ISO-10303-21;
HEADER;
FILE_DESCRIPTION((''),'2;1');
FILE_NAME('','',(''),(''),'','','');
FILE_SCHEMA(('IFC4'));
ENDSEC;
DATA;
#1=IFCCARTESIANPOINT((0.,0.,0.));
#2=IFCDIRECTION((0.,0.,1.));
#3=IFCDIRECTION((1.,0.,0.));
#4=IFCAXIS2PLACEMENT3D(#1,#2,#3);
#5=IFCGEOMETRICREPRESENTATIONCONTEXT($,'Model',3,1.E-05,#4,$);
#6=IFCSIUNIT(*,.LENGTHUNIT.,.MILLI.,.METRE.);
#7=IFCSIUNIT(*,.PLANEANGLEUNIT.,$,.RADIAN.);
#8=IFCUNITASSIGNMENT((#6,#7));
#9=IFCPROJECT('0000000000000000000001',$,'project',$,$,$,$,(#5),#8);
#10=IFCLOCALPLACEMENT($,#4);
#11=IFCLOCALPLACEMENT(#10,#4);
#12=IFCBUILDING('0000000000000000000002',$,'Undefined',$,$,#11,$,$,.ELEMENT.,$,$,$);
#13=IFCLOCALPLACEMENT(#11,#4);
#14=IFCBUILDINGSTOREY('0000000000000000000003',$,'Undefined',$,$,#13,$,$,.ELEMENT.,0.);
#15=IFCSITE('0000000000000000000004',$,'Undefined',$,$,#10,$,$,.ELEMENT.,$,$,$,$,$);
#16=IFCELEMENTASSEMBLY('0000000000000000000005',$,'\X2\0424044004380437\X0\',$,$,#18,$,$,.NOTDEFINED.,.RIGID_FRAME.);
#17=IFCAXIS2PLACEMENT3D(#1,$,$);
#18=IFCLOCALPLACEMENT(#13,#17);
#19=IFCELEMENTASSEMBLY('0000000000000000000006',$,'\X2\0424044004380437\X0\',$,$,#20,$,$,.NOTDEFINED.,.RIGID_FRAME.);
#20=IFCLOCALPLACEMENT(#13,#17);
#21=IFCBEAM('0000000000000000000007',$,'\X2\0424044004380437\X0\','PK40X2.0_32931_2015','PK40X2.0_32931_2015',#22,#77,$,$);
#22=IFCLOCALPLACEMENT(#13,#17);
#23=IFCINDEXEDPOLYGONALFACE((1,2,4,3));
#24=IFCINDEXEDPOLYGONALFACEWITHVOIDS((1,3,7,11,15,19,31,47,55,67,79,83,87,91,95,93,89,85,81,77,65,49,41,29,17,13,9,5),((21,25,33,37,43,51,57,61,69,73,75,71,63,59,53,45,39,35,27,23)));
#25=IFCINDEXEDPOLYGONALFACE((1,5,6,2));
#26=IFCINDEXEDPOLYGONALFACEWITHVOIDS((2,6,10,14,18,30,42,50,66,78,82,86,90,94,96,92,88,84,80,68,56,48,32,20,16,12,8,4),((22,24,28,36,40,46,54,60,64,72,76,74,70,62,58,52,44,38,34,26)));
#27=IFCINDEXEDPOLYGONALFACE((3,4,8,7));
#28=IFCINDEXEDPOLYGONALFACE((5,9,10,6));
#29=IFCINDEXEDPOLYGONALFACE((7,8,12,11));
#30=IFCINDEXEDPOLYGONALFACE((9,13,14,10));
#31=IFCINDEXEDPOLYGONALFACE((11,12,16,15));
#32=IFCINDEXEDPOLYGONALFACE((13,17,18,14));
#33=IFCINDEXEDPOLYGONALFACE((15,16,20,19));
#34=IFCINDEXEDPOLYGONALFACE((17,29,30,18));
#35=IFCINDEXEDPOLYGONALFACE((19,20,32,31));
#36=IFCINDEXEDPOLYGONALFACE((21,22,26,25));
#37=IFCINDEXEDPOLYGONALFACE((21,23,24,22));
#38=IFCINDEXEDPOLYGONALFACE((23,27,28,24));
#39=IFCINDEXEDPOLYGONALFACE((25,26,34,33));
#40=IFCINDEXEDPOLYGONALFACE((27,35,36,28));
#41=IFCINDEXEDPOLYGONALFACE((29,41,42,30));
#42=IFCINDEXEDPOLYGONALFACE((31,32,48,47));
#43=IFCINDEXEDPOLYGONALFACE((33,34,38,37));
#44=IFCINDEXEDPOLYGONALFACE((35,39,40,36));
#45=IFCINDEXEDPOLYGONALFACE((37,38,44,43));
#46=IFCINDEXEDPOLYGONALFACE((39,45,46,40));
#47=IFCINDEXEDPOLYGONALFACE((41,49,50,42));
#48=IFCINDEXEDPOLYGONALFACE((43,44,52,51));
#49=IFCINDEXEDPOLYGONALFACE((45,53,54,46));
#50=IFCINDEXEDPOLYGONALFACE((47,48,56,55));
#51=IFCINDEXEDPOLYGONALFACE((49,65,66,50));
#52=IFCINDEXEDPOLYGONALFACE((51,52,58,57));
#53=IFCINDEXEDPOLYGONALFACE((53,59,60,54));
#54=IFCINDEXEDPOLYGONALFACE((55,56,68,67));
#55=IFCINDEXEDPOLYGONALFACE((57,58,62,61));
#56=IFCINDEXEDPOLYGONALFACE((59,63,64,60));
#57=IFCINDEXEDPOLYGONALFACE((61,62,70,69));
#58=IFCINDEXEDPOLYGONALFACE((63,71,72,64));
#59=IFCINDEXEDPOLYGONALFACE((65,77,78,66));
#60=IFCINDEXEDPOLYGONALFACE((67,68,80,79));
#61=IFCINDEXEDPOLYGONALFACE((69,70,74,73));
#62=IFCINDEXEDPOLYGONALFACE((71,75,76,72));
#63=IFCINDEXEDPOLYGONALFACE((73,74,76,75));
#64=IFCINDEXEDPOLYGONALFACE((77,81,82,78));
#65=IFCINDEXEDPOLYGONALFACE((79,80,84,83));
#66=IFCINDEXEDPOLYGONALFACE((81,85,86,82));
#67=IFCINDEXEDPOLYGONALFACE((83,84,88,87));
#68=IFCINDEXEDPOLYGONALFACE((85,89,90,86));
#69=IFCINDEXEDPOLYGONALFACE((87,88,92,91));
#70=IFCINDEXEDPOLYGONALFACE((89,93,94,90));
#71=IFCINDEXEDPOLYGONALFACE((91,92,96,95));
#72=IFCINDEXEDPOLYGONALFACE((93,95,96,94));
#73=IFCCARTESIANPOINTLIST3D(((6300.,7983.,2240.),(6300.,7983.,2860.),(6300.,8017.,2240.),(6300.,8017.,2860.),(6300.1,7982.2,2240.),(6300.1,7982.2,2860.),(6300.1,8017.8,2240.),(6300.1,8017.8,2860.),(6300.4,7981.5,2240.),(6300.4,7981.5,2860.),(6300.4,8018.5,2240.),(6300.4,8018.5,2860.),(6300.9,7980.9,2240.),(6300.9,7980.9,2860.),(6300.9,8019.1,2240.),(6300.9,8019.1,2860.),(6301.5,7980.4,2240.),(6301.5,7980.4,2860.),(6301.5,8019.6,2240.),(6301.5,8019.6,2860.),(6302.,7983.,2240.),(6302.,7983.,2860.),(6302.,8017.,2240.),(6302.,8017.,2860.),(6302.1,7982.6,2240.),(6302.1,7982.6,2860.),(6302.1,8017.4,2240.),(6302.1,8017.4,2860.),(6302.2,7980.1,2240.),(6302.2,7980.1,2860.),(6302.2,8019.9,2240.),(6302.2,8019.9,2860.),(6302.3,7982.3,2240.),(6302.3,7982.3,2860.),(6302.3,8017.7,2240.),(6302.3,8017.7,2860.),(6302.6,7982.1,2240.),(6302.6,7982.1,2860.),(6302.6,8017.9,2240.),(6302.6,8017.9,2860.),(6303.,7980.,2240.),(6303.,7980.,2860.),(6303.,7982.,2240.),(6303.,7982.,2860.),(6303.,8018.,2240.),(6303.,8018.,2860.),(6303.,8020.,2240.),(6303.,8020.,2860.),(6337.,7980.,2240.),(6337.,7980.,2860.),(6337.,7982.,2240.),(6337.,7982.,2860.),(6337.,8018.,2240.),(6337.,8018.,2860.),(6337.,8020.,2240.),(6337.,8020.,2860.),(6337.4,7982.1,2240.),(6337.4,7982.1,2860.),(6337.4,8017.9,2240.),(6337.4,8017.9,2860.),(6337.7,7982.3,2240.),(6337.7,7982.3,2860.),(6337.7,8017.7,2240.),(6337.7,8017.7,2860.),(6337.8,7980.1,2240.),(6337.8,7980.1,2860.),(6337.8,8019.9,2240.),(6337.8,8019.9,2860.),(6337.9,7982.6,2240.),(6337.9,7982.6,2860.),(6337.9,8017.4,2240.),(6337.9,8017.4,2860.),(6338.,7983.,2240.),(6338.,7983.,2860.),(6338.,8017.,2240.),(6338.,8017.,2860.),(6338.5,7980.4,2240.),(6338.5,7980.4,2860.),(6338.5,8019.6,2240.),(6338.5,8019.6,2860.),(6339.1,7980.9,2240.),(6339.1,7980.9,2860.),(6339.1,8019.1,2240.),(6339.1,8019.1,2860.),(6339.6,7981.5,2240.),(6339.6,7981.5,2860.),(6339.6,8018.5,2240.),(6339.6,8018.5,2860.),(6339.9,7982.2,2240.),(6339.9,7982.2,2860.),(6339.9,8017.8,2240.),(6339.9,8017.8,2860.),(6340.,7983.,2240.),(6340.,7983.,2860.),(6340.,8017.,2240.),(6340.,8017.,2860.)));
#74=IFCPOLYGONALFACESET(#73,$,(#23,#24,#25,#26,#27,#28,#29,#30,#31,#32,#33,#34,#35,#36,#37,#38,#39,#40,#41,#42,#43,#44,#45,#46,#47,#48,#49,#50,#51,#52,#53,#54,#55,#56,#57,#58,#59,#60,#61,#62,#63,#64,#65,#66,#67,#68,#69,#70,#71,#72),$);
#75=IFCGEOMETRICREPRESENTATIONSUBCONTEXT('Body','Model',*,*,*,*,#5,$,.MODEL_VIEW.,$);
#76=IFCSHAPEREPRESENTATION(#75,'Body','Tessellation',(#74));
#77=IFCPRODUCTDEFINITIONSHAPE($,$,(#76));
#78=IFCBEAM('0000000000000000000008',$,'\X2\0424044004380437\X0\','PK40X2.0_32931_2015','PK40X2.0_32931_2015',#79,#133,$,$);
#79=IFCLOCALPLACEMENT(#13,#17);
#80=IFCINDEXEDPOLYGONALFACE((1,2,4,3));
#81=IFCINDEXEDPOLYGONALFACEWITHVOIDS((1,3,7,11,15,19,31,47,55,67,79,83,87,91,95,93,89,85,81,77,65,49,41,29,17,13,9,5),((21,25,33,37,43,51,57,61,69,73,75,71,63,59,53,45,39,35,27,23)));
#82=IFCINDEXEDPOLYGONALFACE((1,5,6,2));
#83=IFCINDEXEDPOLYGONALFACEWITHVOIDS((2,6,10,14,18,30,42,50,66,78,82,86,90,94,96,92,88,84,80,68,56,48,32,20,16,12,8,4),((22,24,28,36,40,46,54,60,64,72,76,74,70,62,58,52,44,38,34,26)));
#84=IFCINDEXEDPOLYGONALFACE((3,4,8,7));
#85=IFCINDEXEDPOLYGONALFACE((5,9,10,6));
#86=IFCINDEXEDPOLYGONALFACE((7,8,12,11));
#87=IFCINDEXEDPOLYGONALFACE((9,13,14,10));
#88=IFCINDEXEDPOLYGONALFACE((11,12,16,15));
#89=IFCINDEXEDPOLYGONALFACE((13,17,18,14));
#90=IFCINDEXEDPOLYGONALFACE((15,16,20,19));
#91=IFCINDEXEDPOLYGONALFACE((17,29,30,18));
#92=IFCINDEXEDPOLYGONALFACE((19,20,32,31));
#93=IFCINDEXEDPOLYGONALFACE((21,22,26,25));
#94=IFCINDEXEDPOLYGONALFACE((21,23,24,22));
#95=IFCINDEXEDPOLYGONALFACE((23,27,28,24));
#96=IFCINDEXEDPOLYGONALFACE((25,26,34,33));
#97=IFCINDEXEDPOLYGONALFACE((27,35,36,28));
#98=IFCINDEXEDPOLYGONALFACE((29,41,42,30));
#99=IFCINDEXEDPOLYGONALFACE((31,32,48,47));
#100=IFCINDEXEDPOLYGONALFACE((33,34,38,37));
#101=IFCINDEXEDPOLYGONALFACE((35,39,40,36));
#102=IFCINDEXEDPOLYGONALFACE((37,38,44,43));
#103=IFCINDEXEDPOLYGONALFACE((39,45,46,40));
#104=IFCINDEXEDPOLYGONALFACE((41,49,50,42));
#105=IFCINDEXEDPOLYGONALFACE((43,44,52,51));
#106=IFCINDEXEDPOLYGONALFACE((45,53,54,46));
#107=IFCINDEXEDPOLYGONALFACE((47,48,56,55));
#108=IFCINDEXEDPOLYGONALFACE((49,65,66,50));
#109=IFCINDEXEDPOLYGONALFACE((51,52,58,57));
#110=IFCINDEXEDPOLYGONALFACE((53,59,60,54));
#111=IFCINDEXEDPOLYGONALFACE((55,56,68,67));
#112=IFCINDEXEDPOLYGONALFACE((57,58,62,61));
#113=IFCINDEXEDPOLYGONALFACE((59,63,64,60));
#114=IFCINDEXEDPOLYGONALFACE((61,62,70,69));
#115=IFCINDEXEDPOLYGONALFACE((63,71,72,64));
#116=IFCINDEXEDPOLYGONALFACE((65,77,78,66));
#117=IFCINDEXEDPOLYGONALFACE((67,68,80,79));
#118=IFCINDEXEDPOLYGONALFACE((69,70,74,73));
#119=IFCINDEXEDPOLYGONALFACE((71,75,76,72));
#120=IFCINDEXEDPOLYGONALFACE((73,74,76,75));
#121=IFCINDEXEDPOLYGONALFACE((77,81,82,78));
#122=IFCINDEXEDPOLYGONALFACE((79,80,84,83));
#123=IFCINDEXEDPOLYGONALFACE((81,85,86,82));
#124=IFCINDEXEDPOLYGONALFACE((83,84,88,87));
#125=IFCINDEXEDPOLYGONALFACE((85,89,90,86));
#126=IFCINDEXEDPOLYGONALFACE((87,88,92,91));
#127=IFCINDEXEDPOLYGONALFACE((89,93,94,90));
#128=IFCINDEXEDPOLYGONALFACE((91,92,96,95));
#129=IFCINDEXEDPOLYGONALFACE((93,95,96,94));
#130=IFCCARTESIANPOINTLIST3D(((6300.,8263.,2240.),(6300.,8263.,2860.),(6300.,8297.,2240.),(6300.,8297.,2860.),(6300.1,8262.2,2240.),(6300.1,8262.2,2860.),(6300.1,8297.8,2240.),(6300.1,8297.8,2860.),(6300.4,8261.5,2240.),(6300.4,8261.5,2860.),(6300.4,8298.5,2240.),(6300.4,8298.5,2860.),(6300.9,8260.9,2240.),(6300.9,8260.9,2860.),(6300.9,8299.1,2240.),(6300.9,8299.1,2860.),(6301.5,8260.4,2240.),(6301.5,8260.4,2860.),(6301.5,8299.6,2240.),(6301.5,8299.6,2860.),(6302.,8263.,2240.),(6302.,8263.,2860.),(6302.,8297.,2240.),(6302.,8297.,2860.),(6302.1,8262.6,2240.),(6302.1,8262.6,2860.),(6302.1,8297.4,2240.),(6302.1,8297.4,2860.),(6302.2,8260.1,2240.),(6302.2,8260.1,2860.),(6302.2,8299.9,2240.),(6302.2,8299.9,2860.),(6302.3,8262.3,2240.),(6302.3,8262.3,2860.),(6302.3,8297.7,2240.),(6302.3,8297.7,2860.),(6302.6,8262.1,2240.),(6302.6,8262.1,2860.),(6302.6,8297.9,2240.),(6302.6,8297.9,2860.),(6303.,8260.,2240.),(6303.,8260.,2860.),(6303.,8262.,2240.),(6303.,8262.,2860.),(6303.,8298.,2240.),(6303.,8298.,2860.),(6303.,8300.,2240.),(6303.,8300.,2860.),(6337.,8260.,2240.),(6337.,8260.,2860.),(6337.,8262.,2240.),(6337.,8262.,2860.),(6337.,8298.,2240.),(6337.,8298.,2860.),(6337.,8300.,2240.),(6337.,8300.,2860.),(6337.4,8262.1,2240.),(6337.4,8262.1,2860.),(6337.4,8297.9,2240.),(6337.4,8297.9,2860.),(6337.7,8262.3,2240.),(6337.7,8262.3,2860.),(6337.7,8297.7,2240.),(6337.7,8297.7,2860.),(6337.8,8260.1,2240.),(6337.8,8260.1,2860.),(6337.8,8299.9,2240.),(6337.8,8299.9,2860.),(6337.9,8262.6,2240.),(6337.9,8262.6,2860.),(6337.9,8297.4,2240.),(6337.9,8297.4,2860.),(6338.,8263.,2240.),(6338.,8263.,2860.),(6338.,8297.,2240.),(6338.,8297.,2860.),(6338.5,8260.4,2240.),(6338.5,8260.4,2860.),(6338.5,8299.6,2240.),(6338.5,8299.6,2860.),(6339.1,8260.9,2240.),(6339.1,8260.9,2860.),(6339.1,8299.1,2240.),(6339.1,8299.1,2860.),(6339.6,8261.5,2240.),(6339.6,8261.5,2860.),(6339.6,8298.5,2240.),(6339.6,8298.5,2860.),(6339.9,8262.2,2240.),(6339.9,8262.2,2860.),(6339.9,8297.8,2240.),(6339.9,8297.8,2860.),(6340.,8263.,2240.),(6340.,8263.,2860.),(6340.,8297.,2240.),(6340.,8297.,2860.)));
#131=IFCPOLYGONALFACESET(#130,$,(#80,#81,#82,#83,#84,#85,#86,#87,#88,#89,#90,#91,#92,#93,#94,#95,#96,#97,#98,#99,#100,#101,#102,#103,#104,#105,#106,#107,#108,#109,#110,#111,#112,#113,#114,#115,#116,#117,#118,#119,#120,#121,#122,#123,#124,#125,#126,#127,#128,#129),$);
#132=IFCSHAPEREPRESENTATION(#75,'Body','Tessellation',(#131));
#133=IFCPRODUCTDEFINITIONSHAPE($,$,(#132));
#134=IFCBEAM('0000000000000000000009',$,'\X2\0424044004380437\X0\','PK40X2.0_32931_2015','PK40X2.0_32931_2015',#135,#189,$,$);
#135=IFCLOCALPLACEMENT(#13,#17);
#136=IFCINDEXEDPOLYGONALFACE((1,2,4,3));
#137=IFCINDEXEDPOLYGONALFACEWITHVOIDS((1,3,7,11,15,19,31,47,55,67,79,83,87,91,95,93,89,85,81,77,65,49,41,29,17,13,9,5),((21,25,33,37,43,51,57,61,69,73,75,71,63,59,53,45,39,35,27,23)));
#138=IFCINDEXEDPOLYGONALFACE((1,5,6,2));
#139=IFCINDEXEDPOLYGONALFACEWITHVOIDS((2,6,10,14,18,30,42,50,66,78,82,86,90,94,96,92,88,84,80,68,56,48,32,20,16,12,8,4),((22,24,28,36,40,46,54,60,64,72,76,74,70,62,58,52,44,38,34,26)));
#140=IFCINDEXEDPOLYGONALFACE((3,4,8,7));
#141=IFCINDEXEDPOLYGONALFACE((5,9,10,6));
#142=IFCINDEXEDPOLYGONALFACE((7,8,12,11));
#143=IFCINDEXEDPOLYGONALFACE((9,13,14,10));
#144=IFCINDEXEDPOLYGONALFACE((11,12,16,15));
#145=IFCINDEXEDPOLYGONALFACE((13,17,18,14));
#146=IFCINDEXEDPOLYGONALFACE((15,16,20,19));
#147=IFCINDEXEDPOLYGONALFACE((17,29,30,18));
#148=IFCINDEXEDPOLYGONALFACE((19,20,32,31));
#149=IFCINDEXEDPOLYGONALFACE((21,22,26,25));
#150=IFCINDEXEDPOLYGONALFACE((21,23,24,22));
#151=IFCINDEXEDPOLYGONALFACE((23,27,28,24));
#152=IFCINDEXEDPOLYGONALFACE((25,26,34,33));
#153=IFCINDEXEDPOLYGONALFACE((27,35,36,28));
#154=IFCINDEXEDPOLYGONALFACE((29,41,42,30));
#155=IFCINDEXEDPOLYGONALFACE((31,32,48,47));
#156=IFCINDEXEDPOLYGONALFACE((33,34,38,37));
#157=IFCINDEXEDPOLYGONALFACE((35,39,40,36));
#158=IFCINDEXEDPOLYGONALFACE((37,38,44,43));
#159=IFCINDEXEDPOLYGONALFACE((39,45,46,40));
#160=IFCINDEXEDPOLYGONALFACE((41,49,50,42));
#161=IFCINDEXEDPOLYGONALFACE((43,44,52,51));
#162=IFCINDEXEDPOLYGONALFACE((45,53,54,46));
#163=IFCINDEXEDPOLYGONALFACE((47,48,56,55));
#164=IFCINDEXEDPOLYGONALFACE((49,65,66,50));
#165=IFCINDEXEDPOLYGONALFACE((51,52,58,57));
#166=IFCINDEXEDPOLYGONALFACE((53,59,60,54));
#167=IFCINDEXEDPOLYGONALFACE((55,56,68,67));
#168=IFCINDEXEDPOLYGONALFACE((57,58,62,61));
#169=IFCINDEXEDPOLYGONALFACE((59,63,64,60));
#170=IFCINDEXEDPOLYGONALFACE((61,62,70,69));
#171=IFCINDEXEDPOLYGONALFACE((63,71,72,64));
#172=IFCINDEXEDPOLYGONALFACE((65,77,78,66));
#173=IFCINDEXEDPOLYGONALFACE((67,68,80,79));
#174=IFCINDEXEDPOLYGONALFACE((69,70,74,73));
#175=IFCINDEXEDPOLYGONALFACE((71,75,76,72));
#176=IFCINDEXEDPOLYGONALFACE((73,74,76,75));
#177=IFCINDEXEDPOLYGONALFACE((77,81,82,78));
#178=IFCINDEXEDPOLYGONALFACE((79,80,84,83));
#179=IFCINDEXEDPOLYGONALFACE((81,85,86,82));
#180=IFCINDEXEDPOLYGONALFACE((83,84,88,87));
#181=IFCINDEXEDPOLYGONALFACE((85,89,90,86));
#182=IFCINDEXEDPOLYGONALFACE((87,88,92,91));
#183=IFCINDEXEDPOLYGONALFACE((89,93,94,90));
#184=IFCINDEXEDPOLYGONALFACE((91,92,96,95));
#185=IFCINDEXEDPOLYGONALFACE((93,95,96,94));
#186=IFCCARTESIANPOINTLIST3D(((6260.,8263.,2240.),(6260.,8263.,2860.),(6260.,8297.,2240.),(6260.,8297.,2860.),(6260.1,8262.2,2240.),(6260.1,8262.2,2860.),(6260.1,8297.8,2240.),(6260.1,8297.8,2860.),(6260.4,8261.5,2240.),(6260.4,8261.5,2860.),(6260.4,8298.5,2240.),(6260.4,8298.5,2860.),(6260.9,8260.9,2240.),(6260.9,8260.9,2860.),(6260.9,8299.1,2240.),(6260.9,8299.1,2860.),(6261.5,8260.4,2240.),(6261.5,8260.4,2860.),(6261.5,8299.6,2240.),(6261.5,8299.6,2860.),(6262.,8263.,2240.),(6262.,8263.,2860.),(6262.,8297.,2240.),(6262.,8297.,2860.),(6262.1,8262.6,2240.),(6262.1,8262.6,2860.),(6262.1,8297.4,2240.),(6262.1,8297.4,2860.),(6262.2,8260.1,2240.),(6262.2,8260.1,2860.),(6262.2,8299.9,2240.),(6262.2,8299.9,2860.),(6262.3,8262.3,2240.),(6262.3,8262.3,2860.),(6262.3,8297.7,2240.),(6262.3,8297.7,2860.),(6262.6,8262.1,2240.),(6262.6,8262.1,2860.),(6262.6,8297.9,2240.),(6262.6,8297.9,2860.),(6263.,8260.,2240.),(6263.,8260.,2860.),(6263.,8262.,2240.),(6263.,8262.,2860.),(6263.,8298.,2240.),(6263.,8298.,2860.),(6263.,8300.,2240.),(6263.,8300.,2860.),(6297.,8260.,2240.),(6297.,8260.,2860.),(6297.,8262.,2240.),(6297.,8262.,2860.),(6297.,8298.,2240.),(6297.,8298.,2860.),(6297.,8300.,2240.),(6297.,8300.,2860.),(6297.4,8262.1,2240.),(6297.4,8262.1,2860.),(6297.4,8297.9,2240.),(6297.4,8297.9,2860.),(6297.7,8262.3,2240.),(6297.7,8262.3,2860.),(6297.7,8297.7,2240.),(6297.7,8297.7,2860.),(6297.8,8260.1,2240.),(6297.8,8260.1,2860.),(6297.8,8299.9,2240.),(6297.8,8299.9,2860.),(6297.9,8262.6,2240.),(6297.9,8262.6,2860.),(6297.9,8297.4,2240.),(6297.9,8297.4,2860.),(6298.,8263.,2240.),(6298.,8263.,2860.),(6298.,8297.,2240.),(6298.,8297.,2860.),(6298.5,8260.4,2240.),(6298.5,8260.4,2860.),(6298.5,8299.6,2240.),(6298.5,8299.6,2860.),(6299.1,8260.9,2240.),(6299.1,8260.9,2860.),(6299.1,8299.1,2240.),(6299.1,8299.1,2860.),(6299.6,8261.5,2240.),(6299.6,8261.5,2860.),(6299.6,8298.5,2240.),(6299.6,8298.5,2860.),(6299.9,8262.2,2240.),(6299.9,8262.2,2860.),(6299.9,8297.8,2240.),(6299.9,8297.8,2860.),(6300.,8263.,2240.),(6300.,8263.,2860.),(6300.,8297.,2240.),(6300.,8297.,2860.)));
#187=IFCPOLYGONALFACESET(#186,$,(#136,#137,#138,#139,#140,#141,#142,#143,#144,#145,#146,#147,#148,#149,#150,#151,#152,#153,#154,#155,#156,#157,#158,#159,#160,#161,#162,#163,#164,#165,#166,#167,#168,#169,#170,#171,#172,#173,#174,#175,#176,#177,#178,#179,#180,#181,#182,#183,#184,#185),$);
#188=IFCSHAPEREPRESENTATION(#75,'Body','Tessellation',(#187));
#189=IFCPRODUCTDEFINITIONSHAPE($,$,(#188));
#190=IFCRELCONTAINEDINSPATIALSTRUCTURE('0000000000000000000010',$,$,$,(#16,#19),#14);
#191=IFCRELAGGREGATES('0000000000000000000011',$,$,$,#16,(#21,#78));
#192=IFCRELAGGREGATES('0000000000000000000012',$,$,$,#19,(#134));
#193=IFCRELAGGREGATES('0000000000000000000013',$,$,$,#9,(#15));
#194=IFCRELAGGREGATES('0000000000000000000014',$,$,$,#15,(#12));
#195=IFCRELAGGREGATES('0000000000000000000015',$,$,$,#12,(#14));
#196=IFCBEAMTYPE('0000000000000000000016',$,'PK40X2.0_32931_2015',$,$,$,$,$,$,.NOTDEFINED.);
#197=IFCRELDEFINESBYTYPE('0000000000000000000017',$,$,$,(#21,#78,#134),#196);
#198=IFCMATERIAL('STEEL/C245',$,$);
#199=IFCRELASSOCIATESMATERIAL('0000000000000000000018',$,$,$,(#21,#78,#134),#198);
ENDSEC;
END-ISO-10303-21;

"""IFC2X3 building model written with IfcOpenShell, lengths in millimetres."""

from ifc_helpers import new_model, si_unit, frame, origin_with_axes, origin_2d_with_axis, place, context, subcontext, project, spatial, hollow_rectangle, extrude, material, type_object, element, aggregate, save


model = new_model("IFC2X3")

# Units and contexts
model_context = context("Model", 3, precision=1e-05, world=origin_with_axes())
body_context = subcontext(model_context, "Body", "Model", "MODEL_VIEW")
ifc_project = project(units=[si_unit("LENGTHUNIT", "METRE", prefix="MILLI"), si_unit("PLANEANGLEUNIT", "RADIAN")], contexts=[model_context])

# Site, building, storey
site_placement = place(None, origin_with_axes())
site = spatial("IfcSite", under=ifc_project, at=site_placement, Name="Undefined", CompositionType="ELEMENT")
building_placement = place(site_placement, origin_with_axes())
building = spatial("IfcBuilding", under=site, at=building_placement, Name="Undefined", CompositionType="ELEMENT")
storey_placement = place(building_placement, origin_with_axes())
storey = spatial("IfcBuildingStorey", under=building, at=storey_placement, Name="Undefined", CompositionType="ELEMENT", Elevation=0.0)

# Shared definitions
ifc_material_1 = material(Name="STEEL/C245")

# Element assembly
assembly_1_placement = place(storey_placement, origin_with_axes())
assembly_1 = element("IfcElementAssembly", 1, at=assembly_1_placement, inside=storey, Name="Фриз", AssemblyPlace="NOTDEFINED", PredefinedType="RIGID_FRAME")

# Shared definitions
beam_type_1 = type_object("IfcBeamType", Name="PK40X2.0_32931_2015", PredefinedType="NOTDEFINED")

# Element assembly
assembly_2_placement = place(storey_placement, origin_with_axes())
assembly_2 = element("IfcElementAssembly", 2, at=assembly_2_placement, inside=storey, Name="Фриз", AssemblyPlace="NOTDEFINED", PredefinedType="RIGID_FRAME")

# Beams
beam_1_placement = place(assembly_1_placement, frame((6320.0, 8000.0, 2860.0), z_axis=(-1.0, 0.0, 0.0), x_axis=(0.0, 0.0, -1.0)))
beam_1 = element("IfcBeam", 3, at=beam_1_placement, type_object=beam_type_1, material=ifc_material_1, Name="Фриз", Description="PK40X2.0_32931_2015", ObjectType="PK40X2.0_32931_2015", context=body_context, shape_type="SweptSolid", body=[
    extrude(hollow_rectangle(XDim=40.0, YDim=40.0, WallThickness=2.0, InnerFilletRadius=1.0, OuterFilletRadius=3.0, at=origin_2d_with_axis()), frame((620.0, 0.0, 0.0), z_axis=(-1.0, 0.0, 0.0), x_axis=(0.0, -1.0, 0.0)), (0.0, 0.0, 1.0), 620.0),
])
beam_2_placement = place(assembly_1_placement, frame((6320.0, 8280.0, 2860.0), z_axis=(-1.0, 0.0, 0.0), x_axis=(0.0, 0.0, -1.0)))
beam_2 = element("IfcBeam", 4, at=beam_2_placement, type_object=beam_type_1, material=ifc_material_1, Name="Фриз", Description="PK40X2.0_32931_2015", ObjectType="PK40X2.0_32931_2015", context=body_context, shape_type="SweptSolid", body=[
    extrude(hollow_rectangle(XDim=40.0, YDim=40.0, WallThickness=2.0, InnerFilletRadius=1.0, OuterFilletRadius=3.0, at=origin_2d_with_axis()), frame((620.0, 0.0, 0.0), z_axis=(-1.0, 0.0, 0.0), x_axis=(0.0, -1.0, 0.0)), (0.0, 0.0, 1.0), 620.0),
])
aggregate(assembly_1, [beam_1, beam_2])
beam_3_placement = place(assembly_2_placement, frame((6280.0, 8280.0, 2860.0), z_axis=(1.0, 0.0, 0.0), x_axis=(0.0, 0.0, -1.0)))
beam_3 = element("IfcBeam", 5, at=beam_3_placement, type_object=beam_type_1, material=ifc_material_1, Name="Фриз", Description="PK40X2.0_32931_2015", ObjectType="PK40X2.0_32931_2015", context=body_context, shape_type="SweptSolid", body=[
    extrude(hollow_rectangle(XDim=40.0, YDim=40.0, WallThickness=2.0, InnerFilletRadius=1.0, OuterFilletRadius=3.0, at=origin_2d_with_axis()), frame((620.0, 0.0, 0.0), z_axis=(-1.0, 0.0, 0.0), x_axis=(0.0, -1.0, 0.0)), (0.0, 0.0, 1.0), 620.0),
])
aggregate(assembly_2, [beam_3])

save(model, "model.ifc")
